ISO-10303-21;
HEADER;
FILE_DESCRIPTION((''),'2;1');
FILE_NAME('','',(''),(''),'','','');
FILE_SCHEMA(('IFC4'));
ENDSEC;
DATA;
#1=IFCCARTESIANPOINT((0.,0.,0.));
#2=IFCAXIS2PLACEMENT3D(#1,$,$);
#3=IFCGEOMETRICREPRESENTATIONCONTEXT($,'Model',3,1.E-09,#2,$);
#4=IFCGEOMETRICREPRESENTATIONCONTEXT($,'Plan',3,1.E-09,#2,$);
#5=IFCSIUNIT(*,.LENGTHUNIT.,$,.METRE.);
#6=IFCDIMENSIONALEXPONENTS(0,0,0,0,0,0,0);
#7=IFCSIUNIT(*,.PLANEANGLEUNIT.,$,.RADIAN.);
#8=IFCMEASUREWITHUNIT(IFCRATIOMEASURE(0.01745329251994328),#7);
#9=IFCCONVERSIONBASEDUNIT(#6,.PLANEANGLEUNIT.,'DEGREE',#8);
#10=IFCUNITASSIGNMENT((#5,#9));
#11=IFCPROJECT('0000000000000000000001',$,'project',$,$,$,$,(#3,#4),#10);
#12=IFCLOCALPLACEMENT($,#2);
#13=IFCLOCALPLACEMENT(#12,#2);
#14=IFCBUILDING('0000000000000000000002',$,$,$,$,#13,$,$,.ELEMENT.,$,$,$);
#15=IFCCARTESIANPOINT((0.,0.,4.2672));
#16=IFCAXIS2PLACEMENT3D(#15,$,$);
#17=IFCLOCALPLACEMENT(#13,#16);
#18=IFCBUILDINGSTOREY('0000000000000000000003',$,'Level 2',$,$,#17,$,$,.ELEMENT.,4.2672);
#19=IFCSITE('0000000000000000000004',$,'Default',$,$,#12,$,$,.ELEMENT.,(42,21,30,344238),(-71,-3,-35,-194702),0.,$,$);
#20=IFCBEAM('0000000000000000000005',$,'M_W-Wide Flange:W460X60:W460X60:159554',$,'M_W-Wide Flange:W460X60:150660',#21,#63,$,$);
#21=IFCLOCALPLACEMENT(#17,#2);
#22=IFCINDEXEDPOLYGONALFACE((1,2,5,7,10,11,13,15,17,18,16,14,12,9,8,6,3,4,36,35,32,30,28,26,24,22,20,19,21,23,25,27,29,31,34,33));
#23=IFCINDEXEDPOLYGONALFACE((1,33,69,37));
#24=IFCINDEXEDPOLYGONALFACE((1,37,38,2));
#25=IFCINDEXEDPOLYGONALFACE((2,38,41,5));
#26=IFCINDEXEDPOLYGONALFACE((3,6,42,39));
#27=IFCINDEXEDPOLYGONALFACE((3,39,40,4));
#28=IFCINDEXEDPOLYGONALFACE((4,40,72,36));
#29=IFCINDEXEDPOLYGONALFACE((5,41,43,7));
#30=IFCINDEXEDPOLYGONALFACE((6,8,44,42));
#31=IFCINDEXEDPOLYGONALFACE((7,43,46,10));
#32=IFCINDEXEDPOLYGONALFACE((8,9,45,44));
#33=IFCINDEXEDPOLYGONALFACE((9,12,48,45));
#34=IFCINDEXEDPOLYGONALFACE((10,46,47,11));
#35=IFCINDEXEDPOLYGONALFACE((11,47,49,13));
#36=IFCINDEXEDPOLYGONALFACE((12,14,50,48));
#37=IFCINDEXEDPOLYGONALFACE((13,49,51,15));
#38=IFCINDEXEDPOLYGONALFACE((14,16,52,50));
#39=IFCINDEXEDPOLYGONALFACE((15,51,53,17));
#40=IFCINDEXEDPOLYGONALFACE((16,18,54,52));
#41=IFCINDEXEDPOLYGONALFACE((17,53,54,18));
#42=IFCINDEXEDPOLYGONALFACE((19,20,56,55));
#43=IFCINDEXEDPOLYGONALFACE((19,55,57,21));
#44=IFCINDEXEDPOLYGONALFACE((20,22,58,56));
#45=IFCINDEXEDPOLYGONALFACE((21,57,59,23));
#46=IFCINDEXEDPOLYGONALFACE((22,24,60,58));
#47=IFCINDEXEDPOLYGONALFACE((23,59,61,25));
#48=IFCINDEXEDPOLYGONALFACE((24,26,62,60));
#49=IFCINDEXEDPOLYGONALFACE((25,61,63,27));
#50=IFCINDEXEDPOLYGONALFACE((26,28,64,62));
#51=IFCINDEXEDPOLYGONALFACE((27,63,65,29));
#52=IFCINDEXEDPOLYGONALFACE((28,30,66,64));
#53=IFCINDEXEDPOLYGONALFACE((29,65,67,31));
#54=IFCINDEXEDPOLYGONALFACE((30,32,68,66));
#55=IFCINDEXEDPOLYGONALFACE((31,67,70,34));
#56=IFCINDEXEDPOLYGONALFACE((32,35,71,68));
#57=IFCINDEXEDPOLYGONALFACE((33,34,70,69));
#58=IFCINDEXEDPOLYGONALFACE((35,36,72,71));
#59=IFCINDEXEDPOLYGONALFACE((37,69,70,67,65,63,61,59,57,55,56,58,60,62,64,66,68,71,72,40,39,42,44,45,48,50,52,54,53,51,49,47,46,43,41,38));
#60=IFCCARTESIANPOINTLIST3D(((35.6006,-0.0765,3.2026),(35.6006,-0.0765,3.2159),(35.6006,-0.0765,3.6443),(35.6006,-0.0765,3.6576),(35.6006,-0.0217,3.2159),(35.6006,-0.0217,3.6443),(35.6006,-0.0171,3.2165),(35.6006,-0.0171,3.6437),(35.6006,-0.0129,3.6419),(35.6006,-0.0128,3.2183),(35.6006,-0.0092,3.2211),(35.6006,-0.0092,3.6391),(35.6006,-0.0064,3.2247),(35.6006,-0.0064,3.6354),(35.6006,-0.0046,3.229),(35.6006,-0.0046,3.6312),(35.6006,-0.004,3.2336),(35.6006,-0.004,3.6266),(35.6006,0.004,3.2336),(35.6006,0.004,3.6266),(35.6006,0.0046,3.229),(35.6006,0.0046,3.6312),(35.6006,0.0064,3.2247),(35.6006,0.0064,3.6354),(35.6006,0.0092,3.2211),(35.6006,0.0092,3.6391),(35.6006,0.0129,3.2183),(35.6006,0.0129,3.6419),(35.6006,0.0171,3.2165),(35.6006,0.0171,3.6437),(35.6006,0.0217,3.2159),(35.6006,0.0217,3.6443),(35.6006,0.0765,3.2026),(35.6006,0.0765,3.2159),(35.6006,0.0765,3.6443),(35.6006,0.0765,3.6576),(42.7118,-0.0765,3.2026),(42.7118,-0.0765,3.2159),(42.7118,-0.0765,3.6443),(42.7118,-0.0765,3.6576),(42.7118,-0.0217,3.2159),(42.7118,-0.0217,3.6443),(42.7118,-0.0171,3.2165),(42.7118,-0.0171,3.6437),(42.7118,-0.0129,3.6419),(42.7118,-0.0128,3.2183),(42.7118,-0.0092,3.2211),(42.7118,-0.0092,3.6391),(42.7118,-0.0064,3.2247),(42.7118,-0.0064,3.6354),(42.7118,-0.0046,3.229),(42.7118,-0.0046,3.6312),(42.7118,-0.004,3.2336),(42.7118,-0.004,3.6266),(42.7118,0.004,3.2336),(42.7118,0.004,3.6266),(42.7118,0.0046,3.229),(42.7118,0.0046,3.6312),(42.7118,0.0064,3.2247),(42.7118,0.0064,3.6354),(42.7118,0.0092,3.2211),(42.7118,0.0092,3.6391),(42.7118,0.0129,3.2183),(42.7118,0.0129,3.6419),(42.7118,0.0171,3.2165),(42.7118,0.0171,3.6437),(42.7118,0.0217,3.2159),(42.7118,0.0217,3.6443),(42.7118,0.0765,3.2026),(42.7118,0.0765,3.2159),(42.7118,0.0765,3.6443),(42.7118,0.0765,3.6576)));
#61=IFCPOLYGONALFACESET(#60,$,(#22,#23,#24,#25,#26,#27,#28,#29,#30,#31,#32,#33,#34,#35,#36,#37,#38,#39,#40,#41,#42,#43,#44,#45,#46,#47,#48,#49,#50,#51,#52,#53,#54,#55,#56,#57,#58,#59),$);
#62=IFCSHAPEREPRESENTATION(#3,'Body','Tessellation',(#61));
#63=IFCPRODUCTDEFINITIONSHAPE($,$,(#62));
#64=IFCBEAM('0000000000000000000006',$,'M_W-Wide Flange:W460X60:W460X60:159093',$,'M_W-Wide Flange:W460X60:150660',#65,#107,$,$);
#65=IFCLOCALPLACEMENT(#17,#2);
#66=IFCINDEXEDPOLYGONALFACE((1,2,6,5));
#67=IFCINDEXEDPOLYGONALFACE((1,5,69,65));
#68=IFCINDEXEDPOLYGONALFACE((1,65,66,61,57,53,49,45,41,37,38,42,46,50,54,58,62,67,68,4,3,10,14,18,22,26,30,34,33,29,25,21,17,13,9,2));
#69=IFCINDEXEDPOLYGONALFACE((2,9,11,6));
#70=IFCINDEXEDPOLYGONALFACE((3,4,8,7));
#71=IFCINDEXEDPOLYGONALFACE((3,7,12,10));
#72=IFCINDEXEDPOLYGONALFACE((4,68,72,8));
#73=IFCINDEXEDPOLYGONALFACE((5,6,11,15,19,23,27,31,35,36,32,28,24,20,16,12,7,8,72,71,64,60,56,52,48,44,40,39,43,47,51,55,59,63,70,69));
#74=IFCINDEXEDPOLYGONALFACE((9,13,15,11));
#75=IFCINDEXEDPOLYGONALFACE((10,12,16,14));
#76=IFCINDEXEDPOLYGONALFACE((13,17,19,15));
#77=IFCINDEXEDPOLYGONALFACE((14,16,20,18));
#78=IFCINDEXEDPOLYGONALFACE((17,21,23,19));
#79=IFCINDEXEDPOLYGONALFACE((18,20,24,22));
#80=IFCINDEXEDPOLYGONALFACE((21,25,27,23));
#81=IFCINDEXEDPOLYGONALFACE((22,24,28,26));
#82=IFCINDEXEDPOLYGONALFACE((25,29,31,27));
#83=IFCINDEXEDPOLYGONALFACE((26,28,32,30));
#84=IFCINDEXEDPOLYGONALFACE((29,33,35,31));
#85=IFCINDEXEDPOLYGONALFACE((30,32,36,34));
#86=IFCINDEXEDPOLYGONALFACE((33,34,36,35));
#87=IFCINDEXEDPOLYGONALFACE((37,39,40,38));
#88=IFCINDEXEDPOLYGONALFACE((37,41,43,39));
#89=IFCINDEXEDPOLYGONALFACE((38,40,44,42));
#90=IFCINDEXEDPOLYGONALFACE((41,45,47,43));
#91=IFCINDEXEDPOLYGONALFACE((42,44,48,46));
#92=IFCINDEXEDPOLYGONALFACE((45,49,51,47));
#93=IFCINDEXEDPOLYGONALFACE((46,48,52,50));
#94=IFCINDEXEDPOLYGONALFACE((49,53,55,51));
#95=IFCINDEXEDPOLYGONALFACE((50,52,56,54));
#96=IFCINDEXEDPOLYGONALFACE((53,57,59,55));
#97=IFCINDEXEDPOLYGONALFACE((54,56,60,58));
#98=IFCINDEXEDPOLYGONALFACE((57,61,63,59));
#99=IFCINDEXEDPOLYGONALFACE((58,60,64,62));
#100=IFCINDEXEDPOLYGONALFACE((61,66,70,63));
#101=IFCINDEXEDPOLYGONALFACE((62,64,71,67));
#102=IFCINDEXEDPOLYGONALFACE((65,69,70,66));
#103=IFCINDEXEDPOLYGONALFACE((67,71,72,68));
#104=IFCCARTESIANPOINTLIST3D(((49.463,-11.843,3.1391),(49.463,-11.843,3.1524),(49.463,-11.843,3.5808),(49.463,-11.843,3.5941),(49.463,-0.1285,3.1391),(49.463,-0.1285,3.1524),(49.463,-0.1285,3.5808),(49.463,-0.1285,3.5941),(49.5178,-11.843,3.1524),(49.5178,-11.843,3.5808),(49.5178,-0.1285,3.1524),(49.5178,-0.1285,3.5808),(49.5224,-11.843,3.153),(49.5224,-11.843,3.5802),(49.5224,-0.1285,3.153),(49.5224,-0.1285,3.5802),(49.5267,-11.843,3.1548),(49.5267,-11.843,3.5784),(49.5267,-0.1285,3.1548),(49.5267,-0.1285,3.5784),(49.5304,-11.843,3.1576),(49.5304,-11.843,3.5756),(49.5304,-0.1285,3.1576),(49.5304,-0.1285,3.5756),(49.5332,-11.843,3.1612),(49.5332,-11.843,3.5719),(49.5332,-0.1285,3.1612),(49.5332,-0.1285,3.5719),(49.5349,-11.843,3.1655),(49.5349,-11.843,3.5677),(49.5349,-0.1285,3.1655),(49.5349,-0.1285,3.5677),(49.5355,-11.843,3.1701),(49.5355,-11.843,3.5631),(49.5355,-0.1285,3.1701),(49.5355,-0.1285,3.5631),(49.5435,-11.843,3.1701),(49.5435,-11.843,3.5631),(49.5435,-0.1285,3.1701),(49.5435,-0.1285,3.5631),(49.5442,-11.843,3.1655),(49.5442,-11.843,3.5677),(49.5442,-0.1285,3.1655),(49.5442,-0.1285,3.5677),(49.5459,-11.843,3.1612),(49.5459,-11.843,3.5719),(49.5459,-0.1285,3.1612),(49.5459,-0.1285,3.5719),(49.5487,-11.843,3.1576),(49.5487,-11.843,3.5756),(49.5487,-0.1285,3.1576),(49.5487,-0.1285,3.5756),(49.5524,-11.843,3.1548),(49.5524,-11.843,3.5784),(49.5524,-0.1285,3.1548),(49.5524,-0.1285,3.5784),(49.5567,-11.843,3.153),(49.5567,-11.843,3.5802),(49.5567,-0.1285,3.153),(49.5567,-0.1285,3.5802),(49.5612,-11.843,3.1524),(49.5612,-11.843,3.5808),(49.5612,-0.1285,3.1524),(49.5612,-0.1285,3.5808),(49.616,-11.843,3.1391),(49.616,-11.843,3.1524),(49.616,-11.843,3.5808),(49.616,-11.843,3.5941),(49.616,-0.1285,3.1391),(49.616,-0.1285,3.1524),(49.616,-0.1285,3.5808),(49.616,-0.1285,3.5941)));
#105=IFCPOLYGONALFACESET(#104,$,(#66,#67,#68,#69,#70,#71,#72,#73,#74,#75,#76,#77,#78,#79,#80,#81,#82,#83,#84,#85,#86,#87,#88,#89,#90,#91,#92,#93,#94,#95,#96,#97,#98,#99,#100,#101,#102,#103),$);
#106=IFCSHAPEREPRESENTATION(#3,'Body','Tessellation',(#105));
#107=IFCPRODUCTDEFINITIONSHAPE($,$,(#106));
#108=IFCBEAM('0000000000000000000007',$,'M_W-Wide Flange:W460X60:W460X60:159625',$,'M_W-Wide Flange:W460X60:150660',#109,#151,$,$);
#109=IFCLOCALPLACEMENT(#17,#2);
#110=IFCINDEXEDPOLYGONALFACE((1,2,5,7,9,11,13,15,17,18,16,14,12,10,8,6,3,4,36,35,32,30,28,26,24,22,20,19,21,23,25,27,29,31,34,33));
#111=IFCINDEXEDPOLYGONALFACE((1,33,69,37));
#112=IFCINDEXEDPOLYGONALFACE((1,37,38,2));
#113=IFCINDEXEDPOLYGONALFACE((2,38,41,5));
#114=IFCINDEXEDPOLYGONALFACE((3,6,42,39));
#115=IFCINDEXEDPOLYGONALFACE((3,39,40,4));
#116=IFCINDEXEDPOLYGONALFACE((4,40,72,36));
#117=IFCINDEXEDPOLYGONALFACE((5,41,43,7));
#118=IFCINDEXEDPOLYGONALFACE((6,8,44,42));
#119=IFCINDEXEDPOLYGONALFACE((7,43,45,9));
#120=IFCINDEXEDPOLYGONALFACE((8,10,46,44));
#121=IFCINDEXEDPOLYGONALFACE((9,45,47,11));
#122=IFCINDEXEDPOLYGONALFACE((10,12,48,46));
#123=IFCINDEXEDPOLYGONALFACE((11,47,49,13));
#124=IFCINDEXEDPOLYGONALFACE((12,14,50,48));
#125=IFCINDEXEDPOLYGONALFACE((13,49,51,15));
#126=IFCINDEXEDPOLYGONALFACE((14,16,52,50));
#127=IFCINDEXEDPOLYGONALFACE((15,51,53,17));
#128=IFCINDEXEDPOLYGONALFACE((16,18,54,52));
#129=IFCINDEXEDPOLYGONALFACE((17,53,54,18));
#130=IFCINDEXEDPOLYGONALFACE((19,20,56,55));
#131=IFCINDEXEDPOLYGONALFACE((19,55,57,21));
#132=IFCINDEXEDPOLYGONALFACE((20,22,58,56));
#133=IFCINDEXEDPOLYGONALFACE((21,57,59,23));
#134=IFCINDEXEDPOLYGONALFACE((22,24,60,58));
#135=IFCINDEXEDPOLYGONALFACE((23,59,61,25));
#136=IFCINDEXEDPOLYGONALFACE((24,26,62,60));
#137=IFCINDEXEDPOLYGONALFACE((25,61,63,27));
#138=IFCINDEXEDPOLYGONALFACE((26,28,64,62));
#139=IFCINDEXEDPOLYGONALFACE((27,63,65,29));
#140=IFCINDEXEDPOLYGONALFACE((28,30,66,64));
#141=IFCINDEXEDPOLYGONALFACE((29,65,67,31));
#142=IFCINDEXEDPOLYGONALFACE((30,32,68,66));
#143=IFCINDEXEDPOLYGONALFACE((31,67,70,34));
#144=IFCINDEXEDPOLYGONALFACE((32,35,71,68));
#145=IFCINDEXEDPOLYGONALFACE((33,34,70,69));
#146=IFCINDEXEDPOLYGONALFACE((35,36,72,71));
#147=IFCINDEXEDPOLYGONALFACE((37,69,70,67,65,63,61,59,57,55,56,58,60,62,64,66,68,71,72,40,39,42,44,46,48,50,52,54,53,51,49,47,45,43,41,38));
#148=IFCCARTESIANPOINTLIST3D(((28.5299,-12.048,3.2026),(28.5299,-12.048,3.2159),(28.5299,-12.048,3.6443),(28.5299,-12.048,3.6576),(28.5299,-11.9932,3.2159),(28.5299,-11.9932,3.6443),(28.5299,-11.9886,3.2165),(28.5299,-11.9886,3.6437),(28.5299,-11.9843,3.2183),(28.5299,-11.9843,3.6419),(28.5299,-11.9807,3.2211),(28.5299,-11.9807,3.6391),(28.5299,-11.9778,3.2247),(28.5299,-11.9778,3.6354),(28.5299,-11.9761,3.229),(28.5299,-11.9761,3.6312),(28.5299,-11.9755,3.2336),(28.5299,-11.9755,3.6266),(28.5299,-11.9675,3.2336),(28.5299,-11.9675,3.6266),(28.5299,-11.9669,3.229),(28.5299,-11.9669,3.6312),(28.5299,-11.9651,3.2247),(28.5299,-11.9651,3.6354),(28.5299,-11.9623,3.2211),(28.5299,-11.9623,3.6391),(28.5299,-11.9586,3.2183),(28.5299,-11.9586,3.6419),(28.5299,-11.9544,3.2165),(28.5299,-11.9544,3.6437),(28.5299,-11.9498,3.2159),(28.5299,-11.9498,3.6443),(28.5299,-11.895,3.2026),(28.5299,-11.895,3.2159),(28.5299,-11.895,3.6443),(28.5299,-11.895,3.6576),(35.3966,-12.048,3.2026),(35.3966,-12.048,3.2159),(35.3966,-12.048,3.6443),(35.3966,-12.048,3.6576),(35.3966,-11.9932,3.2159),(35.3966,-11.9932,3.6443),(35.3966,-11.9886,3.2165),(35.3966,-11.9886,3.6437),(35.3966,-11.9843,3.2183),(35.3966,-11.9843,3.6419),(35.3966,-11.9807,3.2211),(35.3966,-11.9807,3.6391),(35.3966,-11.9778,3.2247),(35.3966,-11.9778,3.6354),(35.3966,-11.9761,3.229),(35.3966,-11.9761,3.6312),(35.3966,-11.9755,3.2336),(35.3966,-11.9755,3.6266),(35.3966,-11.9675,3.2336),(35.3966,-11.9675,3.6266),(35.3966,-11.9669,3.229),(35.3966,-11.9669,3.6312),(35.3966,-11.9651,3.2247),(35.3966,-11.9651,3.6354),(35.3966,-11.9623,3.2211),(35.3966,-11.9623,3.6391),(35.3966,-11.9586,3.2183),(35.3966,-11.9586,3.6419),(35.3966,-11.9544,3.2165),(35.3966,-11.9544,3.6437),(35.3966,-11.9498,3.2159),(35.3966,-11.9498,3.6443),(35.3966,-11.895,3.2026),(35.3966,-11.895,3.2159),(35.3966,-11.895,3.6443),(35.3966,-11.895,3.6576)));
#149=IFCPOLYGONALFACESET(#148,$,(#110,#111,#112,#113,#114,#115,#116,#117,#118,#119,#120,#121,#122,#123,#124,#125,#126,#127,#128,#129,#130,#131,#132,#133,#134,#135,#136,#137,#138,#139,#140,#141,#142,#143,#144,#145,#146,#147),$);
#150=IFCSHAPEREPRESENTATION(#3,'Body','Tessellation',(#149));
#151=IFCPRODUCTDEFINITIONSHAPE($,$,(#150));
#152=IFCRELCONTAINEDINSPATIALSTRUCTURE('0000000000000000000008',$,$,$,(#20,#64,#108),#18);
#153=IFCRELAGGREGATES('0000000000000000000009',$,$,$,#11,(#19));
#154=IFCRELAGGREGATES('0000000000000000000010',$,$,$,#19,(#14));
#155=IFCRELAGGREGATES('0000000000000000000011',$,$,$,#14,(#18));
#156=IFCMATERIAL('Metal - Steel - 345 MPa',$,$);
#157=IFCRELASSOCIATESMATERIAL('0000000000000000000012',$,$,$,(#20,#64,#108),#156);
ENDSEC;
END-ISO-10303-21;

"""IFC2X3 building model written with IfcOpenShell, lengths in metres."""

from ifc_helpers import new_model, entity, si_unit, converted_unit, frame, frame_2d, origin, place, context, project, spatial, polyline, circle_curve, parameter, trimmed, segment, composite_curve, outline, extrude, material, element, save


model = new_model("IFC2X3")

# Units and contexts
model_context = context("Model", 3, precision=1e-09, world=origin())
plan_context = context("Plan", 3, precision=1e-09, world=origin())
ifc_project = project(units=[si_unit("LENGTHUNIT", "METRE"), converted_unit("PLANEANGLEUNIT", "DEGREE", entity("IfcRatioMeasure", 0.01745329251994328), si_unit("PLANEANGLEUNIT", "RADIAN"), dimensions=[0, 0, 0, 0, 0, 0, 0])], contexts=[model_context, plan_context])

# Site, building, storey
site_placement = place(None, origin())
site = spatial("IfcSite", under=ifc_project, at=site_placement, Name="Default", CompositionType="ELEMENT", RefLatitude=(42, 21, 30, 344238), RefLongitude=(-71, -3, -35, -194702), RefElevation=0.0)
building_placement = place(site_placement, origin())
building = spatial("IfcBuilding", under=site, at=building_placement, CompositionType="ELEMENT")
storey_placement = place(building_placement, frame((0.0, 0.0, 4.2672)))
storey = spatial("IfcBuildingStorey", under=building, at=storey_placement, Name="Level 2", CompositionType="ELEMENT", Elevation=4.2672)

# Shared definitions
ifc_material = material(Name="Metal - Steel - 345 MPa")

# Beams
beam_1_placement = place(storey_placement, frame((35.4986, 0.0, 3.6576), z_axis=(0.0, 0.0, 1.0), x_axis=(0.0, -1.0, 0.0)))
element("IfcBeam", 1, at=beam_1_placement, inside=storey, material=ifc_material, Name="M_W-Wide Flange:W460X60:W460X60:159554", ObjectType="M_W-Wide Flange:W460X60:150660", context=model_context, shape_type="SweptSolid", body=[
    extrude(outline(composite_curve([segment(polyline([(-0.0765, -0.2142), (-0.0765, -0.2275)]), True, "CONTINUOUS"), segment(polyline([(-0.0765, -0.2275), (0.0765, -0.2275)]), True, "CONTINUOUS"), segment(polyline([(0.0765, -0.2275), (0.0765, -0.2142)]), True, "CONTINUOUS"), segment(polyline([(0.0765, -0.2142), (0.0217, -0.2142)]), True, "CONTINUOUS"), segment(trimmed(circle_curve(frame_2d((0.0217, -0.1965), x_axis=(0.0, -1.0)), 0.0177), [parameter(270.0)], [parameter(360.0)], True, "PARAMETER"), False, "CONTINUOUS"), segment(polyline([(0.004, -0.1965), (0.004, 0.1965)]), True, "CONTINUOUS"), segment(trimmed(circle_curve(frame_2d((0.0217, 0.1965), x_axis=(-1.0, 0.0)), 0.0177), [parameter(270.0)], [parameter(360.0)], True, "PARAMETER"), False, "CONTINUOUS"), segment(polyline([(0.0217, 0.2142), (0.0765, 0.2142)]), True, "CONTINUOUS"), segment(polyline([(0.0765, 0.2142), (0.0765, 0.2275)]), True, "CONTINUOUS"), segment(polyline([(0.0765, 0.2275), (-0.0765, 0.2275)]), True, "CONTINUOUS"), segment(polyline([(-0.0765, 0.2275), (-0.0765, 0.2142)]), True, "CONTINUOUS"), segment(polyline([(-0.0765, 0.2142), (-0.0217, 0.2142)]), True, "CONTINUOUS"), segment(trimmed(circle_curve(frame_2d((-0.0217, 0.1965), x_axis=(0.0, 1.0)), 0.0177), [parameter(270.0)], [parameter(360.0)], True, "PARAMETER"), False, "CONTINUOUS"), segment(polyline([(-0.004, 0.1965), (-0.004, -0.1965)]), True, "CONTINUOUS"), segment(trimmed(circle_curve(frame_2d((-0.0217, -0.1965), x_axis=(1.0, 0.0)), 0.0177), [parameter(270.0)], [parameter(0.0)], True, "PARAMETER"), False, "CONTINUOUS"), segment(polyline([(-0.0217, -0.2142), (-0.0765, -0.2142)]), True, "CONTINUOUS")], self_intersect=False)), frame((0.0, 0.102, -0.2275), z_axis=(0.0, -1.0, 0.0), x_axis=(1.0, 0.0, 0.0)), (0.0, 0.0, -1.0), 7.1112),
])
beam_2_placement = place(storey_placement, frame((49.5395, 0.0, 3.6576), z_axis=(0.0, 0.0, 1.0), x_axis=(-1.0, 0.0, 0.0)))
element("IfcBeam", 2, at=beam_2_placement, inside=storey, material=ifc_material, Name="M_W-Wide Flange:W460X60:W460X60:159093", ObjectType="M_W-Wide Flange:W460X60:150660", context=model_context, shape_type="SweptSolid", body=[
    extrude(outline(composite_curve([segment(polyline([(0.2142, -0.0765), (0.2275, -0.0765)]), True, "CONTINUOUS"), segment(polyline([(0.2275, -0.0765), (0.2275, 0.0765)]), True, "CONTINUOUS"), segment(polyline([(0.2275, 0.0765), (0.2142, 0.0765)]), True, "CONTINUOUS"), segment(polyline([(0.2142, 0.0765), (0.2142, 0.0217)]), True, "CONTINUOUS"), segment(trimmed(circle_curve(frame_2d((0.1965, 0.0217), x_axis=(0.0, 1.0)), 0.0177), [parameter(180.0)], [parameter(270.0)], True, "PARAMETER"), False, "CONTINUOUS"), segment(polyline([(0.1965, 0.004), (-0.1965, 0.004)]), True, "CONTINUOUS"), segment(trimmed(circle_curve(frame_2d((-0.1965, 0.0217), x_axis=(0.0, 1.0)), 0.0177), [parameter(90.0)], [parameter(180.0)], True, "PARAMETER"), False, "CONTINUOUS"), segment(polyline([(-0.2142, 0.0217), (-0.2142, 0.0765)]), True, "CONTINUOUS"), segment(polyline([(-0.2142, 0.0765), (-0.2275, 0.0765)]), True, "CONTINUOUS"), segment(polyline([(-0.2275, 0.0765), (-0.2275, -0.0765)]), True, "CONTINUOUS"), segment(polyline([(-0.2275, -0.0765), (-0.2142, -0.0765)]), True, "CONTINUOUS"), segment(polyline([(-0.2142, -0.0765), (-0.2142, -0.0217)]), True, "CONTINUOUS"), segment(trimmed(circle_curve(frame_2d((-0.1965, -0.0217), x_axis=(0.0, 1.0)), 0.0177), [parameter(360.0)], [parameter(90.0)], True, "PARAMETER"), False, "CONTINUOUS"), segment(polyline([(-0.1965, -0.004), (0.1965, -0.004)]), True, "CONTINUOUS"), segment(trimmed(circle_curve(frame_2d((0.1965, -0.0217), x_axis=(0.0, 1.0)), 0.0177), [parameter(270.0)], [parameter(0.0)], True, "PARAMETER"), False, "CONTINUOUS"), segment(polyline([(0.2142, -0.0217), (0.2142, -0.0765)]), True, "CONTINUOUS")], self_intersect=False)), frame((0.0, 11.843, -0.291), z_axis=(0.0, -1.0, 0.0), x_axis=(0.0, 0.0, -1.0)), (0.0, 0.0, 1.0), 11.7145),
])
beam_3_placement = place(storey_placement, frame((35.4986, -11.9715, 3.6576), z_axis=(0.0, 0.0, 1.0), x_axis=(0.0, 1.0, 0.0)))
element("IfcBeam", 3, at=beam_3_placement, inside=storey, material=ifc_material, Name="M_W-Wide Flange:W460X60:W460X60:159625", ObjectType="M_W-Wide Flange:W460X60:150660", context=model_context, shape_type="SweptSolid", body=[
    extrude(outline(composite_curve([segment(polyline([(0.2142, -0.0765), (0.2275, -0.0765)]), True, "CONTINUOUS"), segment(polyline([(0.2275, -0.0765), (0.2275, 0.0765)]), True, "CONTINUOUS"), segment(polyline([(0.2275, 0.0765), (0.2142, 0.0765)]), True, "CONTINUOUS"), segment(polyline([(0.2142, 0.0765), (0.2142, 0.0217)]), True, "CONTINUOUS"), segment(trimmed(circle_curve(frame_2d((0.1965, 0.0217), x_axis=(1.0, 0.0)), 0.0177), [parameter(270.0)], [parameter(360.0)], True, "PARAMETER"), False, "CONTINUOUS"), segment(polyline([(0.1965, 0.004), (-0.1965, 0.004)]), True, "CONTINUOUS"), segment(trimmed(circle_curve(frame_2d((-0.1965, 0.0217), x_axis=(0.0, -1.0)), 0.0177), [parameter(270.0)], [parameter(360.0)], True, "PARAMETER"), False, "CONTINUOUS"), segment(polyline([(-0.2142, 0.0217), (-0.2142, 0.0765)]), True, "CONTINUOUS"), segment(polyline([(-0.2142, 0.0765), (-0.2275, 0.0765)]), True, "CONTINUOUS"), segment(polyline([(-0.2275, 0.0765), (-0.2275, -0.0765)]), True, "CONTINUOUS"), segment(polyline([(-0.2275, -0.0765), (-0.2142, -0.0765)]), True, "CONTINUOUS"), segment(polyline([(-0.2142, -0.0765), (-0.2142, -0.0217)]), True, "CONTINUOUS"), segment(trimmed(circle_curve(frame_2d((-0.1965, -0.0217), x_axis=(-1.0, 0.0)), 0.0177), [parameter(270.0)], [parameter(360.0)], True, "PARAMETER"), False, "CONTINUOUS"), segment(polyline([(-0.1965, -0.004), (0.1965, -0.004)]), True, "CONTINUOUS"), segment(trimmed(circle_curve(frame_2d((0.1965, -0.0217), x_axis=(0.0, 1.0)), 0.0177), [parameter(270.0)], [parameter(0.0)], True, "PARAMETER"), False, "CONTINUOUS"), segment(polyline([(0.2142, -0.0217), (0.2142, -0.0765)]), True, "CONTINUOUS")], self_intersect=False)), frame((0.0, 6.9688, -0.2275), z_axis=(0.0, -1.0, 0.0), x_axis=(0.0, 0.0, -1.0)), (0.0, 0.0, 1.0), 6.8668),
])

save(model, "model.ifc")
